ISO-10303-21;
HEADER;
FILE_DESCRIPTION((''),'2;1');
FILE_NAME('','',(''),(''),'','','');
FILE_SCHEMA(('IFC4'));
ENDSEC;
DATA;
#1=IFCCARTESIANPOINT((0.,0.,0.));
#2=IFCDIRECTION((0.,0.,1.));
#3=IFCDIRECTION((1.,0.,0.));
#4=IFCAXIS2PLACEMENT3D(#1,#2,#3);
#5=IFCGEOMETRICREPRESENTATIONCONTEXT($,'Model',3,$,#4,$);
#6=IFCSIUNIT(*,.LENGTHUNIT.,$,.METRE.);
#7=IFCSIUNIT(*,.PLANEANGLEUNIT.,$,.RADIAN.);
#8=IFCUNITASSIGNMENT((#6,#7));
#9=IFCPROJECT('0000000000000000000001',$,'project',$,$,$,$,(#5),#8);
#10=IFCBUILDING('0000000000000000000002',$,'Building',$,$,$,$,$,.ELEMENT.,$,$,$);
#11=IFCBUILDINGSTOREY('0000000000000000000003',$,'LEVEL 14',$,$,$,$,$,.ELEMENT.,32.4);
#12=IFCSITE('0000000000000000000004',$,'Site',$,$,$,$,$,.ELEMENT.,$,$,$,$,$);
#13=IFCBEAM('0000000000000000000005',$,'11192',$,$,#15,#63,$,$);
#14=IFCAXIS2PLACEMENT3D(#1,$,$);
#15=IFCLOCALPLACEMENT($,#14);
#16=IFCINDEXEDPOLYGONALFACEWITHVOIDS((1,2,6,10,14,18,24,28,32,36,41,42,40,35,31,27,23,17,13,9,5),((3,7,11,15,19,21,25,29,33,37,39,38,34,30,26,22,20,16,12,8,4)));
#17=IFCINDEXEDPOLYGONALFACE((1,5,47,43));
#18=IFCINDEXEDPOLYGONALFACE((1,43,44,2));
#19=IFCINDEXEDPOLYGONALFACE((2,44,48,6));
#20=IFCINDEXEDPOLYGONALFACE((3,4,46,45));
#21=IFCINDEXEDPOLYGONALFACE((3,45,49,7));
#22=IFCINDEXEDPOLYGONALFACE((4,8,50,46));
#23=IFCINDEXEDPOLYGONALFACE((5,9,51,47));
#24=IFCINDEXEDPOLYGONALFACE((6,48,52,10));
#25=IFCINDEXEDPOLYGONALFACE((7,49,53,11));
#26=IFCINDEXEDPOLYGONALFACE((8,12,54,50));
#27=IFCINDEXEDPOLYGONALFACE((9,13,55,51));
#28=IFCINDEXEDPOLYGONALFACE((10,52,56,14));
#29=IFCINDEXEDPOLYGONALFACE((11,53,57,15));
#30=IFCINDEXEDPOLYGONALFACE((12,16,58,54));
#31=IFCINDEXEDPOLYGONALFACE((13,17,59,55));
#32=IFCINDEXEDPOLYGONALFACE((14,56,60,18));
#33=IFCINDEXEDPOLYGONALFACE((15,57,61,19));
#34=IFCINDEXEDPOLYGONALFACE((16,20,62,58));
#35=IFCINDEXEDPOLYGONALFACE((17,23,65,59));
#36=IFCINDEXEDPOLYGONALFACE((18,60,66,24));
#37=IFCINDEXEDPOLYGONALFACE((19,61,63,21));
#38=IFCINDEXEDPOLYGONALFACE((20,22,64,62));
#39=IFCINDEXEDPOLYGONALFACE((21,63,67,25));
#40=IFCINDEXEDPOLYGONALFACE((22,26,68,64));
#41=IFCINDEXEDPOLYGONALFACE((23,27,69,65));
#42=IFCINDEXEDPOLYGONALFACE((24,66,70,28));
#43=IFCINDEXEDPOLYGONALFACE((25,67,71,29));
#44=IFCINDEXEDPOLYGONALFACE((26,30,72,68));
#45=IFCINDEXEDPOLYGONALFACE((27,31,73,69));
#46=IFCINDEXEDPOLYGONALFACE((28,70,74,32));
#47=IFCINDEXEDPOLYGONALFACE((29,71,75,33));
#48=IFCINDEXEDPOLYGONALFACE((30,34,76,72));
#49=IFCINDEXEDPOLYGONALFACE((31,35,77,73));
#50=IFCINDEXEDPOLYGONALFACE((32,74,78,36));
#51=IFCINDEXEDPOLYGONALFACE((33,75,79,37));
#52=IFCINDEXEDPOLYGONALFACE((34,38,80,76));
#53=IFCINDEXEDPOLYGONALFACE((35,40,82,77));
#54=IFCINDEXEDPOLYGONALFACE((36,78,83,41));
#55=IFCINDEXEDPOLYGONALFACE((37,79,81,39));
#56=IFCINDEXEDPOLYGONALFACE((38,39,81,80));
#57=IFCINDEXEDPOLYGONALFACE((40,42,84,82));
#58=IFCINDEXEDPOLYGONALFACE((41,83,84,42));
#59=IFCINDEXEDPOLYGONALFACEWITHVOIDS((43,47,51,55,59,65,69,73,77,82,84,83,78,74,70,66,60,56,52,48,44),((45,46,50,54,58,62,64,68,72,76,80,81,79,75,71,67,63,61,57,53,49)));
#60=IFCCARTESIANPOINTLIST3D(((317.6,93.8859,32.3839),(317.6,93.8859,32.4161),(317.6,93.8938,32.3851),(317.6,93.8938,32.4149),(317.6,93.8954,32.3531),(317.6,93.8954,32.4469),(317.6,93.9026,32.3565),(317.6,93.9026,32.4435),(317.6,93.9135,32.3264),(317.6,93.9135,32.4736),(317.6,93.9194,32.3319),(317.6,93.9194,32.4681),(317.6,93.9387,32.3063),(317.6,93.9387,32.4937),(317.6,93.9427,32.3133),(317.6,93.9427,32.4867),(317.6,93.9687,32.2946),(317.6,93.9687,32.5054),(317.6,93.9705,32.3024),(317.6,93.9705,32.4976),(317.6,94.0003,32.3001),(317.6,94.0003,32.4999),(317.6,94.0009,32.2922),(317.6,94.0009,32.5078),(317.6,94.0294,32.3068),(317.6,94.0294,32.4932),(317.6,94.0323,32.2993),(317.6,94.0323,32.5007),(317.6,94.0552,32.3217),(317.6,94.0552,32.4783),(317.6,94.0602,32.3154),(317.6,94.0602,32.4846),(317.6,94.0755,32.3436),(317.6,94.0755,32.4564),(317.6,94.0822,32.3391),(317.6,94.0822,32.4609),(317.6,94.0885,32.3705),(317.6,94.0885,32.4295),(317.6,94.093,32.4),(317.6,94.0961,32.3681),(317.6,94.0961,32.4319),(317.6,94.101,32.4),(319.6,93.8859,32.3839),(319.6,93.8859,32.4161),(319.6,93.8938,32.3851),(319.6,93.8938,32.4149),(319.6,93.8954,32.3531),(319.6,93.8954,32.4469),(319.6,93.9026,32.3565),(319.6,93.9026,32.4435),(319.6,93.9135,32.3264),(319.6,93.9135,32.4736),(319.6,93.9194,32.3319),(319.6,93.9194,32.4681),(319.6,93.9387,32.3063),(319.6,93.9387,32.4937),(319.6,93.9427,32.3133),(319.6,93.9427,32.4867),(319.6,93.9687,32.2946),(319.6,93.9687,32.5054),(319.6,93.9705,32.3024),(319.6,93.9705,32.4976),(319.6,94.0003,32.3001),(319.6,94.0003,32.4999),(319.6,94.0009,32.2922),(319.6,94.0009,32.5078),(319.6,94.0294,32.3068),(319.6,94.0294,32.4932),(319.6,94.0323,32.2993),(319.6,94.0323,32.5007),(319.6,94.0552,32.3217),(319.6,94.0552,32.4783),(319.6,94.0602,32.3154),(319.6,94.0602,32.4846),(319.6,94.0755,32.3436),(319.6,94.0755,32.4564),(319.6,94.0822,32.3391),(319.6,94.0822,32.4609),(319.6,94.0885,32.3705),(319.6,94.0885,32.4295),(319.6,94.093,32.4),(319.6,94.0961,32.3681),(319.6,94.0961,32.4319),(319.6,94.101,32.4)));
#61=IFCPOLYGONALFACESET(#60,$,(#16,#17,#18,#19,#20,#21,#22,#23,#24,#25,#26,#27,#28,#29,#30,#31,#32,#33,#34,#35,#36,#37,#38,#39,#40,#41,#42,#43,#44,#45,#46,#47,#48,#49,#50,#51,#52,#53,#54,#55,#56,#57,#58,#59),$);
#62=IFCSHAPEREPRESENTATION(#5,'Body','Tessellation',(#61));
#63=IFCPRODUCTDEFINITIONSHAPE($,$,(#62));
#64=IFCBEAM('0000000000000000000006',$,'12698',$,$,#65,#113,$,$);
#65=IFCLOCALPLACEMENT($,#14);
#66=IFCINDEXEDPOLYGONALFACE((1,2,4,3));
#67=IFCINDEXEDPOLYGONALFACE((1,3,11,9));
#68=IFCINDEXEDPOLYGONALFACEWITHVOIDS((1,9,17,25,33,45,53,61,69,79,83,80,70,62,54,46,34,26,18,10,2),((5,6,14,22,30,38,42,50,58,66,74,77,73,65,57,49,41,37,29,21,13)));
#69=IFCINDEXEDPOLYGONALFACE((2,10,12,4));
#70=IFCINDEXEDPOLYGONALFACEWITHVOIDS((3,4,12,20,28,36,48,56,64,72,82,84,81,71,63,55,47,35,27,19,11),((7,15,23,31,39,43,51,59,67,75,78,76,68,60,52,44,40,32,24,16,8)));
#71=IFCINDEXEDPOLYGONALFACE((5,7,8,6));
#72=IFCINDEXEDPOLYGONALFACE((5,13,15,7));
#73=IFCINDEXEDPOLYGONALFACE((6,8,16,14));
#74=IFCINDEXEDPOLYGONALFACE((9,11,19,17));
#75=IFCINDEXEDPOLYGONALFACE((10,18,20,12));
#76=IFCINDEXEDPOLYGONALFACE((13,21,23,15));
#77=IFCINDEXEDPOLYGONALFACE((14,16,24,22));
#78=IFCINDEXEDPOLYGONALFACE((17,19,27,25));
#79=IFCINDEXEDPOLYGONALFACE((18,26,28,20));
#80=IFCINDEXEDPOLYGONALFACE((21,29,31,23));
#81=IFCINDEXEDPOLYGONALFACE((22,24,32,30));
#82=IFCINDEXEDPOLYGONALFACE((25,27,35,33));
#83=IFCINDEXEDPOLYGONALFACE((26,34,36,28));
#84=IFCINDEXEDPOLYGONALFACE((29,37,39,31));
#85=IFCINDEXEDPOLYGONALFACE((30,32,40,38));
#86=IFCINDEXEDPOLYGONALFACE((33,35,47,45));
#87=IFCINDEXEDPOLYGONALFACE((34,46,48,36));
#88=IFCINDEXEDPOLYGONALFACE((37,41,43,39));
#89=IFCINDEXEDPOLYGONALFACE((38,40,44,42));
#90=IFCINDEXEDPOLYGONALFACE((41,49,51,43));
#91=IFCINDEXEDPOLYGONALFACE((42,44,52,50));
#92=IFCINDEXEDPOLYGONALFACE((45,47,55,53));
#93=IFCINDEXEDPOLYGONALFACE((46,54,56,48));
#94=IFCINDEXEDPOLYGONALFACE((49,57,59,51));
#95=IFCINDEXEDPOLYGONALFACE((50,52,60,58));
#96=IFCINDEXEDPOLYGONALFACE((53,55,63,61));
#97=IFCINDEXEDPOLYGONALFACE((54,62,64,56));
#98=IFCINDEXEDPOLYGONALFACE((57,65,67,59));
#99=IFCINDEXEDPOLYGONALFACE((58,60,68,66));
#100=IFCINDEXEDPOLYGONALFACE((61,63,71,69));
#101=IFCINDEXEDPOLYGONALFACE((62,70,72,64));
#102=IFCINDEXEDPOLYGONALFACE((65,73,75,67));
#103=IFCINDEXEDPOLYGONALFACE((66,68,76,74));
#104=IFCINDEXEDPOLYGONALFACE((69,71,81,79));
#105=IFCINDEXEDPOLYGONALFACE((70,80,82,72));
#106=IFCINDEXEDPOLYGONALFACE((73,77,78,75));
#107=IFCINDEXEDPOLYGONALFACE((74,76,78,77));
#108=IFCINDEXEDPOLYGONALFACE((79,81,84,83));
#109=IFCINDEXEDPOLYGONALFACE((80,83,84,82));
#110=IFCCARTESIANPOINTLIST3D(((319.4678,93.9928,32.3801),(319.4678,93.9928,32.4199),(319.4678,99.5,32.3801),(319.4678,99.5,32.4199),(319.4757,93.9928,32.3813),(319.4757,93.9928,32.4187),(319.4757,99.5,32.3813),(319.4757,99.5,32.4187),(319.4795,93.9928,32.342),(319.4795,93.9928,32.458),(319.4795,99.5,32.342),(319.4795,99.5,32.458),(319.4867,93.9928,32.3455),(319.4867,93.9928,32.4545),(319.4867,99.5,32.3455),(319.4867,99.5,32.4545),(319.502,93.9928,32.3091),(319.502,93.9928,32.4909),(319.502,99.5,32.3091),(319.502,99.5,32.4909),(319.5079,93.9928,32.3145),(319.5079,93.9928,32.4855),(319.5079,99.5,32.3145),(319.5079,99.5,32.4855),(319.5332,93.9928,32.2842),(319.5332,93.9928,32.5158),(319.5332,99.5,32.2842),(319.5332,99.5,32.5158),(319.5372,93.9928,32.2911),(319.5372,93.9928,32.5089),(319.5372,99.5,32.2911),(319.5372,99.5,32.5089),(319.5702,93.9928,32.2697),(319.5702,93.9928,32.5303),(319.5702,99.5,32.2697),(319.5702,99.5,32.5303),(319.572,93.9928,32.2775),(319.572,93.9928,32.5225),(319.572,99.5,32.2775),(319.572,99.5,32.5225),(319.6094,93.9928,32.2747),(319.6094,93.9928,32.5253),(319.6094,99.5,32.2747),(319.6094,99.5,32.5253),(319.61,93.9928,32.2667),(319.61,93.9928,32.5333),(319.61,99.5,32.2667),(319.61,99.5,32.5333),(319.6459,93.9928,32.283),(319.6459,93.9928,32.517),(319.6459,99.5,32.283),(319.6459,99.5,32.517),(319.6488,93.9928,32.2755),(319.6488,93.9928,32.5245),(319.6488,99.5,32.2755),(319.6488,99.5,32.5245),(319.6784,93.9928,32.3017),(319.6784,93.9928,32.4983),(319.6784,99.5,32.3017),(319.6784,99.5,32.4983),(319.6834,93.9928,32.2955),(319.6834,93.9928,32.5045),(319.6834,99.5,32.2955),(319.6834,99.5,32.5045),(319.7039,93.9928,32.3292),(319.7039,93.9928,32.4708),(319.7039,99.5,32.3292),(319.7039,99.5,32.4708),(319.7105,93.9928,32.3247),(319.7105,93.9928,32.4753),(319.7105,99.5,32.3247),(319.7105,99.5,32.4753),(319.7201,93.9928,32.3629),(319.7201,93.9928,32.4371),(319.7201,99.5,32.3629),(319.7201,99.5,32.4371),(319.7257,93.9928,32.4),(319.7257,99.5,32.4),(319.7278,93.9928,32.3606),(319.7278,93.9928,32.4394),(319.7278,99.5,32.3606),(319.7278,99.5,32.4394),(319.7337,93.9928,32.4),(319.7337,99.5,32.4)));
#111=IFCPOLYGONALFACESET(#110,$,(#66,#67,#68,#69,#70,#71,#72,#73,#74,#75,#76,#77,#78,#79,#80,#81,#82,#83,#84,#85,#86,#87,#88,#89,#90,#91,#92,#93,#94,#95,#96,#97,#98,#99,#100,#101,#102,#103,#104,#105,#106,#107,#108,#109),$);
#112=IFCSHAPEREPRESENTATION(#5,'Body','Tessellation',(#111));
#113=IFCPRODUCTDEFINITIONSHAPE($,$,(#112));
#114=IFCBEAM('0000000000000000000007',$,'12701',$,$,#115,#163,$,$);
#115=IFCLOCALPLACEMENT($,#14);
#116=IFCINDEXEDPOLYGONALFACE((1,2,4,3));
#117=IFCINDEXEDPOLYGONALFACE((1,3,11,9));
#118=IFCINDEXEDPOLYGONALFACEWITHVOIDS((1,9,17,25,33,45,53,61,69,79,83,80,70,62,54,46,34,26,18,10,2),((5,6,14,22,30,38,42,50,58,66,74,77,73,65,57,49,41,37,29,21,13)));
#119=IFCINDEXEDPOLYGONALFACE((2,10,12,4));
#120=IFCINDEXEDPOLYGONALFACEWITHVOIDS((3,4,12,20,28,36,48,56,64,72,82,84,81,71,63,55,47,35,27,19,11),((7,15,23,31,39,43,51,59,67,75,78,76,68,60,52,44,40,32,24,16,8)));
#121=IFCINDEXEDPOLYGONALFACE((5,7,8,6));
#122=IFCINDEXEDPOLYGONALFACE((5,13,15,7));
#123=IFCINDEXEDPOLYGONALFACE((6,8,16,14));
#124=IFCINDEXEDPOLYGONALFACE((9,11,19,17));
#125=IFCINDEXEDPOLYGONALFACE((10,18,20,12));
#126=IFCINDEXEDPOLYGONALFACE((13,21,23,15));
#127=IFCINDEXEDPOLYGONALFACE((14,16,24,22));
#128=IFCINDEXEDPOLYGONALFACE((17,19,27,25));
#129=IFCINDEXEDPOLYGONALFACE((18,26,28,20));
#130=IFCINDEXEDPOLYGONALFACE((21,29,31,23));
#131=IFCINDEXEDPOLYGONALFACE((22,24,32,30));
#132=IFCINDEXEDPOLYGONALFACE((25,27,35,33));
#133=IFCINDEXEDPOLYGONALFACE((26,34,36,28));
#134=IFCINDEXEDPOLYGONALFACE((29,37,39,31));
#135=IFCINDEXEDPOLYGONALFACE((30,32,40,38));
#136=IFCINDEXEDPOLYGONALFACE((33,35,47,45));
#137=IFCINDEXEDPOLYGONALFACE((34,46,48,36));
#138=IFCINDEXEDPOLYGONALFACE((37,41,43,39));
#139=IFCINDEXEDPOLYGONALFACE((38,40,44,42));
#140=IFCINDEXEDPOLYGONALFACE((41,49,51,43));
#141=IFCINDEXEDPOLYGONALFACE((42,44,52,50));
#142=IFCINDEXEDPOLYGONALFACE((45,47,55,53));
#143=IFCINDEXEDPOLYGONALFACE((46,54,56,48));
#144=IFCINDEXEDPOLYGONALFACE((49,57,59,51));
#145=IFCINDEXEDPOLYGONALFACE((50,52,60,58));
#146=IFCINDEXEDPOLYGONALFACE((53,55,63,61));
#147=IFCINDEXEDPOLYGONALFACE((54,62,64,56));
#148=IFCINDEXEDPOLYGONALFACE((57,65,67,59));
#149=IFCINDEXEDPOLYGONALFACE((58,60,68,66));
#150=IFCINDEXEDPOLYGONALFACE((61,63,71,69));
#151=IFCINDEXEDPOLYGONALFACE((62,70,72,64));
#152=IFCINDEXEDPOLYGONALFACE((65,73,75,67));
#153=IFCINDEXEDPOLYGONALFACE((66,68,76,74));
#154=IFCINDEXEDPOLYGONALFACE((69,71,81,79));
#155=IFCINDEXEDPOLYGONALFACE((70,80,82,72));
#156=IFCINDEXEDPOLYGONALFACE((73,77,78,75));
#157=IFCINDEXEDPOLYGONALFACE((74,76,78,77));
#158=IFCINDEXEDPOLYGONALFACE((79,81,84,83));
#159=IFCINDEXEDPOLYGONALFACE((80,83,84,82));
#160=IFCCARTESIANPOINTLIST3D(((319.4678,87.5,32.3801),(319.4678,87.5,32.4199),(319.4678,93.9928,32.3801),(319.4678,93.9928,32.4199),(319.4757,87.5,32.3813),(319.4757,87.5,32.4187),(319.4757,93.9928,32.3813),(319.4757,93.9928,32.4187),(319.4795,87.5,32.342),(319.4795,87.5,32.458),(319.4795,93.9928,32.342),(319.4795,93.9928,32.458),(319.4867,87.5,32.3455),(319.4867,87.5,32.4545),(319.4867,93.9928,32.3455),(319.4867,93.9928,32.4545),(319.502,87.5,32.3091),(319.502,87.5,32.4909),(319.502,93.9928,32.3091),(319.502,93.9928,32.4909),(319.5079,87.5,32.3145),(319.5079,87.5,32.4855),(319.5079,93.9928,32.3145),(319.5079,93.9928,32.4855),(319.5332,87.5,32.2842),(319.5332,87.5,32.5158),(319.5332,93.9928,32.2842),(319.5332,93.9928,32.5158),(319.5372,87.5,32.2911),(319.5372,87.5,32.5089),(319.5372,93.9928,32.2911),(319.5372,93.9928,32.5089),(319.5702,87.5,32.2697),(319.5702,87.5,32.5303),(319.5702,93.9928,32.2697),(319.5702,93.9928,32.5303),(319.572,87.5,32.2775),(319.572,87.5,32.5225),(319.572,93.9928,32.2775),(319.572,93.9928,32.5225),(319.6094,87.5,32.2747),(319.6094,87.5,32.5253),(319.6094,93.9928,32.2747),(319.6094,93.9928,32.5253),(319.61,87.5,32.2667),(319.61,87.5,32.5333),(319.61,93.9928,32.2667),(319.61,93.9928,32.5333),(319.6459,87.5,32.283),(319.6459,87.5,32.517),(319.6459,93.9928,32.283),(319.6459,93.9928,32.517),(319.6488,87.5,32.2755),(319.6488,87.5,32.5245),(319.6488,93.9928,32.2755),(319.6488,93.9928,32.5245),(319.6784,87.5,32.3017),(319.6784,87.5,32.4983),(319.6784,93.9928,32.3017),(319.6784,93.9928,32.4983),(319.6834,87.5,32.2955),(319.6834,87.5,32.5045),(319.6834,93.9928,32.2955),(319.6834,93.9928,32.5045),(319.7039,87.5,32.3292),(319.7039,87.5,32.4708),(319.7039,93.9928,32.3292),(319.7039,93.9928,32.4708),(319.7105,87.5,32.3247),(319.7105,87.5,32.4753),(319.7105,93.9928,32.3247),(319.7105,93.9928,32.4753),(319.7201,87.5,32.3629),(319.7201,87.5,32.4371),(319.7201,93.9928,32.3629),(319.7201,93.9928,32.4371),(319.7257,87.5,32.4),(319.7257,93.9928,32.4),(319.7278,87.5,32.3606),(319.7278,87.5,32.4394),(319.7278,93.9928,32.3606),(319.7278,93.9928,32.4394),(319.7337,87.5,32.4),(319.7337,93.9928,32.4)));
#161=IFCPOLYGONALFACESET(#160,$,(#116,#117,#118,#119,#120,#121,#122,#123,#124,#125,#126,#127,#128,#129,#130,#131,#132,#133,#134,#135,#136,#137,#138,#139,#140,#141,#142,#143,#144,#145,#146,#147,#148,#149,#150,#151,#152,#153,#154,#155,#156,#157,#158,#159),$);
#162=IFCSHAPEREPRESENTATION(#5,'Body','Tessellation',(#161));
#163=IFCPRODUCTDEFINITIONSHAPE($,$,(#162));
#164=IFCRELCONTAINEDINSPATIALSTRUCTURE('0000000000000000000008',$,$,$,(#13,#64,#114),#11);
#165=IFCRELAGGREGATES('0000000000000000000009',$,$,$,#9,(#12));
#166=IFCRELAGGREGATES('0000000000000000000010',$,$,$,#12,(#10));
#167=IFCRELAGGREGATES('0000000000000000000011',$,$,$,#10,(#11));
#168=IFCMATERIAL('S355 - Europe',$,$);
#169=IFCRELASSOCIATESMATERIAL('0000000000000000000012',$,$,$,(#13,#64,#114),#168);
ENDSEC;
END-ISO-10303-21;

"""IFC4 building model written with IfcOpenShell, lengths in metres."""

from ifc_helpers import new_model, si_unit, frame, origin_with_axes, origin_2d_with_axis, place, context, project, spatial, hollow_circle, extrude, material, material_profile, profile_set, profile_usage, element, save


model = new_model("IFC4")

# Units and contexts
model_context = context("Model", 3, world=origin_with_axes())
ifc_project = project(units=[si_unit("LENGTHUNIT", "METRE"), si_unit("PLANEANGLEUNIT", "RADIAN")], contexts=[model_context])

# Site, building, storey
site = spatial("IfcSite", under=ifc_project, Name="Site", CompositionType="ELEMENT")
building = spatial("IfcBuilding", under=site, Name="Building", CompositionType="ELEMENT")
storey = spatial("IfcBuildingStorey", under=building, Name="LEVEL 14", CompositionType="ELEMENT", Elevation=32.4)

# Shared definitions
ifc_material = material(Name="S355 - Europe")

# Beams
ifc_material_profile_1 = material_profile(ifc_material, hollow_circle(Radius=0.1081, WallThickness=0.008, at=origin_2d_with_axis()))
ifc_profile_set_1 = profile_set([ifc_material_profile_1])
ifc_profile_usage_1 = profile_usage(ifc_profile_set_1, cardinal=10)
beam_1_placement = place(None, frame((317.6, 93.9928, 32.4), z_axis=(1.0, 0.0, 0.0), x_axis=(0.0, 1.0, 0.0)))
element("IfcBeam", 1, at=beam_1_placement, inside=storey, material=ifc_profile_usage_1, Name="11192", context=model_context, shape_type="SweptSolid", body=[
    extrude(hollow_circle(Radius=0.1081, WallThickness=0.008, at=origin_2d_with_axis()), origin_with_axes(), (0.0, 0.0, 1.0), 2.0),
])
ifc_material_profile_2 = material_profile(ifc_material, hollow_circle(Radius=0.1337, WallThickness=0.008, at=origin_2d_with_axis()))
ifc_profile_set_2 = profile_set([ifc_material_profile_2])
ifc_profile_usage_2 = profile_usage(ifc_profile_set_2, cardinal=10)
beam_2_placement = place(None, frame((319.6, 99.5, 32.4), z_axis=(0.0, -1.0, 0.0), x_axis=(1.0, 0.0, 0.0)))
element("IfcBeam", 2, at=beam_2_placement, inside=storey, material=ifc_profile_usage_2, Name="12698", context=model_context, shape_type="SweptSolid", body=[
    extrude(hollow_circle(Radius=0.1337, WallThickness=0.008, at=origin_2d_with_axis()), origin_with_axes(), (0.0, 0.0, 1.0), 5.5072),
])
ifc_material_profile_3 = material_profile(ifc_material, hollow_circle(Radius=0.1337, WallThickness=0.008, at=origin_2d_with_axis()))
ifc_profile_set_3 = profile_set([ifc_material_profile_3])
ifc_profile_usage_3 = profile_usage(ifc_profile_set_3, cardinal=10)
beam_3_placement = place(None, frame((319.6, 93.9928, 32.4), z_axis=(0.0, -1.0, 0.0), x_axis=(1.0, 0.0, 0.0)))
element("IfcBeam", 3, at=beam_3_placement, inside=storey, material=ifc_profile_usage_3, Name="12701", context=model_context, shape_type="SweptSolid", body=[
    extrude(hollow_circle(Radius=0.1337, WallThickness=0.008, at=origin_2d_with_axis()), origin_with_axes(), (0.0, 0.0, 1.0), 6.4928),
])

save(model, "model.ifc")
